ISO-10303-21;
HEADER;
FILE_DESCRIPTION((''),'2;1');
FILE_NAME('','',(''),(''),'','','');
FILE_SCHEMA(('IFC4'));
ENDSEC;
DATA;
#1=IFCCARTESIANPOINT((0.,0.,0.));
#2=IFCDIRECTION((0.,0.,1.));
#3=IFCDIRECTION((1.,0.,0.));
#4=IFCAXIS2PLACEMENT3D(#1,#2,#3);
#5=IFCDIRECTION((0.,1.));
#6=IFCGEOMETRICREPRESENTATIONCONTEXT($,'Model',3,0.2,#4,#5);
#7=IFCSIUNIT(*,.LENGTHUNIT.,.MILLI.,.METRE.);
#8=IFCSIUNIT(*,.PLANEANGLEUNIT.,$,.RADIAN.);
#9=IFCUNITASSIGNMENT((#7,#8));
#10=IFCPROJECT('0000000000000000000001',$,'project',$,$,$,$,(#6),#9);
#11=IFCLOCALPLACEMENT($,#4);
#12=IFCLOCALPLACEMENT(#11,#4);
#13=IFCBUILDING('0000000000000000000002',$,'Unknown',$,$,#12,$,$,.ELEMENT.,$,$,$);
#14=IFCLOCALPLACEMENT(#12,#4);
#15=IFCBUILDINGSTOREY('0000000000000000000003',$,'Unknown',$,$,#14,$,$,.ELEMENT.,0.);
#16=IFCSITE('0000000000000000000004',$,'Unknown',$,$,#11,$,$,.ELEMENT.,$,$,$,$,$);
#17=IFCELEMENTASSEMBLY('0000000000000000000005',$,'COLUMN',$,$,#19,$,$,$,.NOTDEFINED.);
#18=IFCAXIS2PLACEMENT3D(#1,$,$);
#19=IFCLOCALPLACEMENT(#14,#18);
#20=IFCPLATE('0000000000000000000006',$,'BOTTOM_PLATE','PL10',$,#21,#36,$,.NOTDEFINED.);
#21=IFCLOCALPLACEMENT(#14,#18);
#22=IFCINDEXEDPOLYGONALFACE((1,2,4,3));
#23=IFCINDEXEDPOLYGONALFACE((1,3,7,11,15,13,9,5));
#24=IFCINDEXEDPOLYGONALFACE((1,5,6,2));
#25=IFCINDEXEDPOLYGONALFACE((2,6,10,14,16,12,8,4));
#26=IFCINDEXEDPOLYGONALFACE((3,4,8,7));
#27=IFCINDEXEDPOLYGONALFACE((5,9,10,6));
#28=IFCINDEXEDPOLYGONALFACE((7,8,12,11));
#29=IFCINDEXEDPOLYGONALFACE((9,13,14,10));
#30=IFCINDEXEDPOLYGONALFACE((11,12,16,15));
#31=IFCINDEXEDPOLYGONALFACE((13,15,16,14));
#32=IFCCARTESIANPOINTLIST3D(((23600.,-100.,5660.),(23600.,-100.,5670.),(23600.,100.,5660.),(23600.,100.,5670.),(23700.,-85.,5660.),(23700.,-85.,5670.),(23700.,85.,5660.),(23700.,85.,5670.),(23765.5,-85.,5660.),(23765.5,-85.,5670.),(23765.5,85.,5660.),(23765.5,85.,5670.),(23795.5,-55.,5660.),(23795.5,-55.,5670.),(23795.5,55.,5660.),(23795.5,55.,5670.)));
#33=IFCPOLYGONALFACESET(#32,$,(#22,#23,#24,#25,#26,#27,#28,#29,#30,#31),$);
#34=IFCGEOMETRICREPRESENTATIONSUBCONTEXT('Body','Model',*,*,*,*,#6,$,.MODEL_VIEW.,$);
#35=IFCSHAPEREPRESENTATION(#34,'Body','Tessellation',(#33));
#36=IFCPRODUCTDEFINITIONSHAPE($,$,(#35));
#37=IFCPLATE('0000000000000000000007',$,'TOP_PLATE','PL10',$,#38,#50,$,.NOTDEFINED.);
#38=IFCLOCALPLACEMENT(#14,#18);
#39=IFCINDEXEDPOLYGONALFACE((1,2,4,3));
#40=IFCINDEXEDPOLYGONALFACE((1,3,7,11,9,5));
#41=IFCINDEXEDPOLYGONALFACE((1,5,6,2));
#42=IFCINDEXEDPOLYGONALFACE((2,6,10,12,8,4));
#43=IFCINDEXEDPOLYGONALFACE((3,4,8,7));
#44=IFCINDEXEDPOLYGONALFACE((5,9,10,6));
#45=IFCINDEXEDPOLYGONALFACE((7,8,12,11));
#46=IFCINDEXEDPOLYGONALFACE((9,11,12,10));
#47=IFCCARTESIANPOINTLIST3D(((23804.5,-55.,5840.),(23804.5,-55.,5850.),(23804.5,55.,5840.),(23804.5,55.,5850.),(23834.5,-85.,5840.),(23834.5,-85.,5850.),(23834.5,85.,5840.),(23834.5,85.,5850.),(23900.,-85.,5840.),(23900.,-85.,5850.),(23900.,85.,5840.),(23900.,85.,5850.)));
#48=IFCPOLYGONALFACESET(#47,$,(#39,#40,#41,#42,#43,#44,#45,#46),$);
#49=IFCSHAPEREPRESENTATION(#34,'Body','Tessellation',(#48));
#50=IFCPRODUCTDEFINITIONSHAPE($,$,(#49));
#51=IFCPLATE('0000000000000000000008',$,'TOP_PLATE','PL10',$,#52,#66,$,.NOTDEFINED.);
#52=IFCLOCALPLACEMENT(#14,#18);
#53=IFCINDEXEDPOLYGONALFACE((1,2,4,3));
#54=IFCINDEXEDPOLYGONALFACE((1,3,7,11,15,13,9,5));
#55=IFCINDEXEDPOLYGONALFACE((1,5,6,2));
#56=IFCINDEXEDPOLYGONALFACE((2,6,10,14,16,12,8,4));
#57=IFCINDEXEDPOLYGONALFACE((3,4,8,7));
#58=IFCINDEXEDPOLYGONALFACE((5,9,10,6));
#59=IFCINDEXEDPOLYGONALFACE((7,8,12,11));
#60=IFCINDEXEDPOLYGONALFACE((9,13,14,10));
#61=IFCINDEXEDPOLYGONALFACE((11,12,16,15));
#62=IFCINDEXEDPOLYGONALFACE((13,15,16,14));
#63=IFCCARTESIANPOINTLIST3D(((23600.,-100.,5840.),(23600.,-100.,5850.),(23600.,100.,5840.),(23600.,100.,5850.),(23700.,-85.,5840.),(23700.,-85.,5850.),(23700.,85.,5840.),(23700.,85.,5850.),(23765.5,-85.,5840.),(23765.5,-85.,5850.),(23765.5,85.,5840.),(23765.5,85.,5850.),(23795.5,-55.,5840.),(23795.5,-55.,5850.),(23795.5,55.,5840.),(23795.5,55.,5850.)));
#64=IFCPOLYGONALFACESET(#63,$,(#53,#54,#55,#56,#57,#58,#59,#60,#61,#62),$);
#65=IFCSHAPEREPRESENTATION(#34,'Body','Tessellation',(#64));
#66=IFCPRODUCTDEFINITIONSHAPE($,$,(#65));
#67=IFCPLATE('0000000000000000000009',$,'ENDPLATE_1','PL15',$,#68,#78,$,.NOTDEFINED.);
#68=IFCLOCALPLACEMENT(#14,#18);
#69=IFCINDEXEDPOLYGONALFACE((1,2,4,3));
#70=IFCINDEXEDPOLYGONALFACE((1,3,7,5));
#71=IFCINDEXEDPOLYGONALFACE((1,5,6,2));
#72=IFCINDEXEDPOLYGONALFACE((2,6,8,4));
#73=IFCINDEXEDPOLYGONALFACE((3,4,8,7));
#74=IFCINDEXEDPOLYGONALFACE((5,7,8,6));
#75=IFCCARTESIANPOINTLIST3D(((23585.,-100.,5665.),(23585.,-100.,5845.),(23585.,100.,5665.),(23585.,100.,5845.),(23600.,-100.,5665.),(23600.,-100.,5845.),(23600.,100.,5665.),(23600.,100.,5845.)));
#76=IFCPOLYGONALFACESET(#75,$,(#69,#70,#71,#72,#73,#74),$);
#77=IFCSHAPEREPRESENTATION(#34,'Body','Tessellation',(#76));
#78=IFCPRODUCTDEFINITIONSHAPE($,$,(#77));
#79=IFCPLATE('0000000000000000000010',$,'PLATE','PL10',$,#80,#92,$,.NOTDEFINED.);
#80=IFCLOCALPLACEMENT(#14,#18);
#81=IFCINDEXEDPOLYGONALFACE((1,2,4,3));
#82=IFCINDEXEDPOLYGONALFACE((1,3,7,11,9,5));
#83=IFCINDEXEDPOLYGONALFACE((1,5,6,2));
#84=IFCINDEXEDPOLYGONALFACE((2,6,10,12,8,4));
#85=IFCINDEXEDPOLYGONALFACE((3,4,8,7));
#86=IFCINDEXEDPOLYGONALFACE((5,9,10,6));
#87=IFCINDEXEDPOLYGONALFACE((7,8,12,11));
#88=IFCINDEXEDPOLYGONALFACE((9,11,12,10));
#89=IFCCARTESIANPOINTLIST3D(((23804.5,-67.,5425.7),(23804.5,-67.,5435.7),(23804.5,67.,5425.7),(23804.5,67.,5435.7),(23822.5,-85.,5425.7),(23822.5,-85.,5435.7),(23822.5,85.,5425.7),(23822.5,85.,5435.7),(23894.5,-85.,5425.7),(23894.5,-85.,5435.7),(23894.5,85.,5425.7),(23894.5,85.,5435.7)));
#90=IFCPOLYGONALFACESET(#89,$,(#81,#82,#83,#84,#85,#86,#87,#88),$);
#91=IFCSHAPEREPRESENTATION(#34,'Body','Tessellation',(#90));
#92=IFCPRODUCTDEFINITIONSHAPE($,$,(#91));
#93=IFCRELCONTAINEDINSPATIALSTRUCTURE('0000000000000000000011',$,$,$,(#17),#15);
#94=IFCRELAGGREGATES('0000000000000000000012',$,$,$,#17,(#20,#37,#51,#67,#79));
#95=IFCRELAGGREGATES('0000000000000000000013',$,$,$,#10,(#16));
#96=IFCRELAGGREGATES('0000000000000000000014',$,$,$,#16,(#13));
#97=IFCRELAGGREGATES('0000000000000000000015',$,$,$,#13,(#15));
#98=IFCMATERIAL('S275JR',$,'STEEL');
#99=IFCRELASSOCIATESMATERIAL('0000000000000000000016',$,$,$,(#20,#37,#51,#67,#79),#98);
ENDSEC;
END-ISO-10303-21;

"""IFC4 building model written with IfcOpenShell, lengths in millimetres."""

from ifc_helpers import new_model, si_unit, direction, frame, origin_with_axes, place, context, subcontext, project, spatial, line, indexed_curve, outline, extrude, material, element, aggregate, save


model = new_model("IFC4")

# Units and contexts
model_context = context("Model", 3, precision=0.2, world=origin_with_axes(), true_north=direction((0.0, 1.0)))
body_context = subcontext(model_context, "Body", "Model", "MODEL_VIEW")
ifc_project = project(units=[si_unit("LENGTHUNIT", "METRE", prefix="MILLI"), si_unit("PLANEANGLEUNIT", "RADIAN")], contexts=[model_context])

# Site, building, storey
site_placement = place(None, origin_with_axes())
site = spatial("IfcSite", under=ifc_project, at=site_placement, Name="Unknown", CompositionType="ELEMENT")
building_placement = place(site_placement, origin_with_axes())
building = spatial("IfcBuilding", under=site, at=building_placement, Name="Unknown", CompositionType="ELEMENT")
storey_placement = place(building_placement, origin_with_axes())
storey = spatial("IfcBuildingStorey", under=building, at=storey_placement, Name="Unknown", CompositionType="ELEMENT", Elevation=0.0)

# Shared definitions
ifc_material_1 = material(Name="S275JR", Category="STEEL")

# Element assembly, plates
assembly_1_placement = place(storey_placement, frame((23800.0, 0.0, 200.0), z_axis=(-1.0, 0.0, 0.0), x_axis=(0.0, 0.0, 1.0)))
assembly_1 = element("IfcElementAssembly", 1, at=assembly_1_placement, inside=storey, Name="COLUMN", PredefinedType="NOTDEFINED")
plate_1_placement = place(assembly_1_placement, frame((5465.0, -85.0, 4.5), z_axis=(1.0, 0.0, 0.0), x_axis=(0.0, 1.0, 0.0)))
plate_1 = element("IfcPlate", 2, at=plate_1_placement, material=ifc_material_1, Name="BOTTOM_PLATE", Description="PL10", PredefinedType="NOTDEFINED", context=body_context, shape_type="SolidModel", body=[
    extrude(outline(indexed_curve([(0.0, 30.0), (30.0, 0.0), (140.0, 0.0), (170.0, 30.0), (170.0, 95.5), (185.0, 195.5), (-15.0, 195.5), (0.0, 95.5)], segments=[line(1, 2, 3, 4, 5, 6, 7, 8, 1)])), frame((0.0, 0.0, 5.0), z_axis=(0.0, 0.0, 1.0), x_axis=(1.0, 0.0, 0.0)), (0.0, -0.000002, -1.0), 10.0),
])
plate_2_placement = place(assembly_1_placement, frame((5645.0, -85.0, -4.5), z_axis=(1.0, 0.0, 0.0), x_axis=(0.0, -0.000002, -1.0)))
plate_2 = element("IfcPlate", 3, at=plate_2_placement, material=ifc_material_1, Name="TOP_PLATE", Description="PL10", PredefinedType="NOTDEFINED", context=body_context, shape_type="SolidModel", body=[
    extrude(outline(indexed_curve([(0.0, 30.0), (30.0, 0.0), (95.5, 0.0), (95.5, 170.0), (30.0, 170.0), (0.0, 140.0)], segments=[line(1, 2, 3, 4, 5, 6, 1)])), frame((0.0, 0.0, 5.0), z_axis=(0.0, 0.0, 1.0), x_axis=(1.0, 0.0, 0.0)), (0.0, -0.000002, -1.0), 10.0),
])
plate_3_placement = place(assembly_1_placement, frame((5645.0, -85.0, 100.0), z_axis=(1.0, 0.0, 0.0), x_axis=(0.0, -0.000002, -1.0)))
plate_3 = element("IfcPlate", 4, at=plate_3_placement, material=ifc_material_1, Name="TOP_PLATE", Description="PL10", PredefinedType="NOTDEFINED", context=body_context, shape_type="SolidModel", body=[
    extrude(outline(indexed_curve([(0.0, 0.0), (65.5, 0.0), (95.5, 30.0), (95.5, 140.0), (65.5, 170.0), (0.0, 170.0), (-100.0, 185.0), (-100.0, -15.0)], segments=[line(1, 2, 3, 4, 5, 6, 7, 8, 1)])), frame((0.0, 0.0, 5.0), z_axis=(0.0, 0.0, 1.0), x_axis=(1.0, 0.0, 0.0)), (0.0, -0.000002, -1.0), 10.0),
])
plate_4_placement = place(assembly_1_placement, frame((5465.0, -100.0, 207.5), z_axis=(0.0, 0.0, 1.0), x_axis=(1.0, 0.0, 0.0)))
plate_4 = element("IfcPlate", 5, at=plate_4_placement, material=ifc_material_1, Name="ENDPLATE_1", Description="PL15", PredefinedType="NOTDEFINED", context=body_context, shape_type="SolidModel", body=[
    extrude(outline(indexed_curve([(0.0, 0.0), (180.0, 0.0), (180.0, 200.0), (0.0, 200.0)], segments=[line(1, 2, 3, 4, 1)])), frame((0.0, 0.0, 7.5), z_axis=(0.0, 0.0, 1.0), x_axis=(1.0, 0.0, 0.0)), (0.0, -0.000002, -1.0), 15.0),
])
plate_5_placement = place(assembly_1_placement, frame((5230.7, 85.0, -94.5), z_axis=(1.0, 0.0, 0.0), x_axis=(0.0, 0.0, 1.0)))
plate_5 = element("IfcPlate", 6, at=plate_5_placement, material=ifc_material_1, Name="PLATE", Description="PL10", PredefinedType="NOTDEFINED", context=body_context, shape_type="SolidModel", body=[
    extrude(outline(indexed_curve([(0.0, 0.0), (72.0, 0.0), (90.0, 18.0), (90.0, 152.0), (72.0, 170.0), (0.0, 170.0)], segments=[line(1, 2, 3, 4, 5, 6, 1)])), frame((0.0, 0.0, 5.0), z_axis=(0.0, 0.0, 1.0), x_axis=(1.0, 0.0, 0.0)), (0.0, -0.000002, -1.0), 10.0),
])
aggregate(assembly_1, [plate_1, plate_2, plate_3, plate_4, plate_5])

save(model, "model.ifc")
